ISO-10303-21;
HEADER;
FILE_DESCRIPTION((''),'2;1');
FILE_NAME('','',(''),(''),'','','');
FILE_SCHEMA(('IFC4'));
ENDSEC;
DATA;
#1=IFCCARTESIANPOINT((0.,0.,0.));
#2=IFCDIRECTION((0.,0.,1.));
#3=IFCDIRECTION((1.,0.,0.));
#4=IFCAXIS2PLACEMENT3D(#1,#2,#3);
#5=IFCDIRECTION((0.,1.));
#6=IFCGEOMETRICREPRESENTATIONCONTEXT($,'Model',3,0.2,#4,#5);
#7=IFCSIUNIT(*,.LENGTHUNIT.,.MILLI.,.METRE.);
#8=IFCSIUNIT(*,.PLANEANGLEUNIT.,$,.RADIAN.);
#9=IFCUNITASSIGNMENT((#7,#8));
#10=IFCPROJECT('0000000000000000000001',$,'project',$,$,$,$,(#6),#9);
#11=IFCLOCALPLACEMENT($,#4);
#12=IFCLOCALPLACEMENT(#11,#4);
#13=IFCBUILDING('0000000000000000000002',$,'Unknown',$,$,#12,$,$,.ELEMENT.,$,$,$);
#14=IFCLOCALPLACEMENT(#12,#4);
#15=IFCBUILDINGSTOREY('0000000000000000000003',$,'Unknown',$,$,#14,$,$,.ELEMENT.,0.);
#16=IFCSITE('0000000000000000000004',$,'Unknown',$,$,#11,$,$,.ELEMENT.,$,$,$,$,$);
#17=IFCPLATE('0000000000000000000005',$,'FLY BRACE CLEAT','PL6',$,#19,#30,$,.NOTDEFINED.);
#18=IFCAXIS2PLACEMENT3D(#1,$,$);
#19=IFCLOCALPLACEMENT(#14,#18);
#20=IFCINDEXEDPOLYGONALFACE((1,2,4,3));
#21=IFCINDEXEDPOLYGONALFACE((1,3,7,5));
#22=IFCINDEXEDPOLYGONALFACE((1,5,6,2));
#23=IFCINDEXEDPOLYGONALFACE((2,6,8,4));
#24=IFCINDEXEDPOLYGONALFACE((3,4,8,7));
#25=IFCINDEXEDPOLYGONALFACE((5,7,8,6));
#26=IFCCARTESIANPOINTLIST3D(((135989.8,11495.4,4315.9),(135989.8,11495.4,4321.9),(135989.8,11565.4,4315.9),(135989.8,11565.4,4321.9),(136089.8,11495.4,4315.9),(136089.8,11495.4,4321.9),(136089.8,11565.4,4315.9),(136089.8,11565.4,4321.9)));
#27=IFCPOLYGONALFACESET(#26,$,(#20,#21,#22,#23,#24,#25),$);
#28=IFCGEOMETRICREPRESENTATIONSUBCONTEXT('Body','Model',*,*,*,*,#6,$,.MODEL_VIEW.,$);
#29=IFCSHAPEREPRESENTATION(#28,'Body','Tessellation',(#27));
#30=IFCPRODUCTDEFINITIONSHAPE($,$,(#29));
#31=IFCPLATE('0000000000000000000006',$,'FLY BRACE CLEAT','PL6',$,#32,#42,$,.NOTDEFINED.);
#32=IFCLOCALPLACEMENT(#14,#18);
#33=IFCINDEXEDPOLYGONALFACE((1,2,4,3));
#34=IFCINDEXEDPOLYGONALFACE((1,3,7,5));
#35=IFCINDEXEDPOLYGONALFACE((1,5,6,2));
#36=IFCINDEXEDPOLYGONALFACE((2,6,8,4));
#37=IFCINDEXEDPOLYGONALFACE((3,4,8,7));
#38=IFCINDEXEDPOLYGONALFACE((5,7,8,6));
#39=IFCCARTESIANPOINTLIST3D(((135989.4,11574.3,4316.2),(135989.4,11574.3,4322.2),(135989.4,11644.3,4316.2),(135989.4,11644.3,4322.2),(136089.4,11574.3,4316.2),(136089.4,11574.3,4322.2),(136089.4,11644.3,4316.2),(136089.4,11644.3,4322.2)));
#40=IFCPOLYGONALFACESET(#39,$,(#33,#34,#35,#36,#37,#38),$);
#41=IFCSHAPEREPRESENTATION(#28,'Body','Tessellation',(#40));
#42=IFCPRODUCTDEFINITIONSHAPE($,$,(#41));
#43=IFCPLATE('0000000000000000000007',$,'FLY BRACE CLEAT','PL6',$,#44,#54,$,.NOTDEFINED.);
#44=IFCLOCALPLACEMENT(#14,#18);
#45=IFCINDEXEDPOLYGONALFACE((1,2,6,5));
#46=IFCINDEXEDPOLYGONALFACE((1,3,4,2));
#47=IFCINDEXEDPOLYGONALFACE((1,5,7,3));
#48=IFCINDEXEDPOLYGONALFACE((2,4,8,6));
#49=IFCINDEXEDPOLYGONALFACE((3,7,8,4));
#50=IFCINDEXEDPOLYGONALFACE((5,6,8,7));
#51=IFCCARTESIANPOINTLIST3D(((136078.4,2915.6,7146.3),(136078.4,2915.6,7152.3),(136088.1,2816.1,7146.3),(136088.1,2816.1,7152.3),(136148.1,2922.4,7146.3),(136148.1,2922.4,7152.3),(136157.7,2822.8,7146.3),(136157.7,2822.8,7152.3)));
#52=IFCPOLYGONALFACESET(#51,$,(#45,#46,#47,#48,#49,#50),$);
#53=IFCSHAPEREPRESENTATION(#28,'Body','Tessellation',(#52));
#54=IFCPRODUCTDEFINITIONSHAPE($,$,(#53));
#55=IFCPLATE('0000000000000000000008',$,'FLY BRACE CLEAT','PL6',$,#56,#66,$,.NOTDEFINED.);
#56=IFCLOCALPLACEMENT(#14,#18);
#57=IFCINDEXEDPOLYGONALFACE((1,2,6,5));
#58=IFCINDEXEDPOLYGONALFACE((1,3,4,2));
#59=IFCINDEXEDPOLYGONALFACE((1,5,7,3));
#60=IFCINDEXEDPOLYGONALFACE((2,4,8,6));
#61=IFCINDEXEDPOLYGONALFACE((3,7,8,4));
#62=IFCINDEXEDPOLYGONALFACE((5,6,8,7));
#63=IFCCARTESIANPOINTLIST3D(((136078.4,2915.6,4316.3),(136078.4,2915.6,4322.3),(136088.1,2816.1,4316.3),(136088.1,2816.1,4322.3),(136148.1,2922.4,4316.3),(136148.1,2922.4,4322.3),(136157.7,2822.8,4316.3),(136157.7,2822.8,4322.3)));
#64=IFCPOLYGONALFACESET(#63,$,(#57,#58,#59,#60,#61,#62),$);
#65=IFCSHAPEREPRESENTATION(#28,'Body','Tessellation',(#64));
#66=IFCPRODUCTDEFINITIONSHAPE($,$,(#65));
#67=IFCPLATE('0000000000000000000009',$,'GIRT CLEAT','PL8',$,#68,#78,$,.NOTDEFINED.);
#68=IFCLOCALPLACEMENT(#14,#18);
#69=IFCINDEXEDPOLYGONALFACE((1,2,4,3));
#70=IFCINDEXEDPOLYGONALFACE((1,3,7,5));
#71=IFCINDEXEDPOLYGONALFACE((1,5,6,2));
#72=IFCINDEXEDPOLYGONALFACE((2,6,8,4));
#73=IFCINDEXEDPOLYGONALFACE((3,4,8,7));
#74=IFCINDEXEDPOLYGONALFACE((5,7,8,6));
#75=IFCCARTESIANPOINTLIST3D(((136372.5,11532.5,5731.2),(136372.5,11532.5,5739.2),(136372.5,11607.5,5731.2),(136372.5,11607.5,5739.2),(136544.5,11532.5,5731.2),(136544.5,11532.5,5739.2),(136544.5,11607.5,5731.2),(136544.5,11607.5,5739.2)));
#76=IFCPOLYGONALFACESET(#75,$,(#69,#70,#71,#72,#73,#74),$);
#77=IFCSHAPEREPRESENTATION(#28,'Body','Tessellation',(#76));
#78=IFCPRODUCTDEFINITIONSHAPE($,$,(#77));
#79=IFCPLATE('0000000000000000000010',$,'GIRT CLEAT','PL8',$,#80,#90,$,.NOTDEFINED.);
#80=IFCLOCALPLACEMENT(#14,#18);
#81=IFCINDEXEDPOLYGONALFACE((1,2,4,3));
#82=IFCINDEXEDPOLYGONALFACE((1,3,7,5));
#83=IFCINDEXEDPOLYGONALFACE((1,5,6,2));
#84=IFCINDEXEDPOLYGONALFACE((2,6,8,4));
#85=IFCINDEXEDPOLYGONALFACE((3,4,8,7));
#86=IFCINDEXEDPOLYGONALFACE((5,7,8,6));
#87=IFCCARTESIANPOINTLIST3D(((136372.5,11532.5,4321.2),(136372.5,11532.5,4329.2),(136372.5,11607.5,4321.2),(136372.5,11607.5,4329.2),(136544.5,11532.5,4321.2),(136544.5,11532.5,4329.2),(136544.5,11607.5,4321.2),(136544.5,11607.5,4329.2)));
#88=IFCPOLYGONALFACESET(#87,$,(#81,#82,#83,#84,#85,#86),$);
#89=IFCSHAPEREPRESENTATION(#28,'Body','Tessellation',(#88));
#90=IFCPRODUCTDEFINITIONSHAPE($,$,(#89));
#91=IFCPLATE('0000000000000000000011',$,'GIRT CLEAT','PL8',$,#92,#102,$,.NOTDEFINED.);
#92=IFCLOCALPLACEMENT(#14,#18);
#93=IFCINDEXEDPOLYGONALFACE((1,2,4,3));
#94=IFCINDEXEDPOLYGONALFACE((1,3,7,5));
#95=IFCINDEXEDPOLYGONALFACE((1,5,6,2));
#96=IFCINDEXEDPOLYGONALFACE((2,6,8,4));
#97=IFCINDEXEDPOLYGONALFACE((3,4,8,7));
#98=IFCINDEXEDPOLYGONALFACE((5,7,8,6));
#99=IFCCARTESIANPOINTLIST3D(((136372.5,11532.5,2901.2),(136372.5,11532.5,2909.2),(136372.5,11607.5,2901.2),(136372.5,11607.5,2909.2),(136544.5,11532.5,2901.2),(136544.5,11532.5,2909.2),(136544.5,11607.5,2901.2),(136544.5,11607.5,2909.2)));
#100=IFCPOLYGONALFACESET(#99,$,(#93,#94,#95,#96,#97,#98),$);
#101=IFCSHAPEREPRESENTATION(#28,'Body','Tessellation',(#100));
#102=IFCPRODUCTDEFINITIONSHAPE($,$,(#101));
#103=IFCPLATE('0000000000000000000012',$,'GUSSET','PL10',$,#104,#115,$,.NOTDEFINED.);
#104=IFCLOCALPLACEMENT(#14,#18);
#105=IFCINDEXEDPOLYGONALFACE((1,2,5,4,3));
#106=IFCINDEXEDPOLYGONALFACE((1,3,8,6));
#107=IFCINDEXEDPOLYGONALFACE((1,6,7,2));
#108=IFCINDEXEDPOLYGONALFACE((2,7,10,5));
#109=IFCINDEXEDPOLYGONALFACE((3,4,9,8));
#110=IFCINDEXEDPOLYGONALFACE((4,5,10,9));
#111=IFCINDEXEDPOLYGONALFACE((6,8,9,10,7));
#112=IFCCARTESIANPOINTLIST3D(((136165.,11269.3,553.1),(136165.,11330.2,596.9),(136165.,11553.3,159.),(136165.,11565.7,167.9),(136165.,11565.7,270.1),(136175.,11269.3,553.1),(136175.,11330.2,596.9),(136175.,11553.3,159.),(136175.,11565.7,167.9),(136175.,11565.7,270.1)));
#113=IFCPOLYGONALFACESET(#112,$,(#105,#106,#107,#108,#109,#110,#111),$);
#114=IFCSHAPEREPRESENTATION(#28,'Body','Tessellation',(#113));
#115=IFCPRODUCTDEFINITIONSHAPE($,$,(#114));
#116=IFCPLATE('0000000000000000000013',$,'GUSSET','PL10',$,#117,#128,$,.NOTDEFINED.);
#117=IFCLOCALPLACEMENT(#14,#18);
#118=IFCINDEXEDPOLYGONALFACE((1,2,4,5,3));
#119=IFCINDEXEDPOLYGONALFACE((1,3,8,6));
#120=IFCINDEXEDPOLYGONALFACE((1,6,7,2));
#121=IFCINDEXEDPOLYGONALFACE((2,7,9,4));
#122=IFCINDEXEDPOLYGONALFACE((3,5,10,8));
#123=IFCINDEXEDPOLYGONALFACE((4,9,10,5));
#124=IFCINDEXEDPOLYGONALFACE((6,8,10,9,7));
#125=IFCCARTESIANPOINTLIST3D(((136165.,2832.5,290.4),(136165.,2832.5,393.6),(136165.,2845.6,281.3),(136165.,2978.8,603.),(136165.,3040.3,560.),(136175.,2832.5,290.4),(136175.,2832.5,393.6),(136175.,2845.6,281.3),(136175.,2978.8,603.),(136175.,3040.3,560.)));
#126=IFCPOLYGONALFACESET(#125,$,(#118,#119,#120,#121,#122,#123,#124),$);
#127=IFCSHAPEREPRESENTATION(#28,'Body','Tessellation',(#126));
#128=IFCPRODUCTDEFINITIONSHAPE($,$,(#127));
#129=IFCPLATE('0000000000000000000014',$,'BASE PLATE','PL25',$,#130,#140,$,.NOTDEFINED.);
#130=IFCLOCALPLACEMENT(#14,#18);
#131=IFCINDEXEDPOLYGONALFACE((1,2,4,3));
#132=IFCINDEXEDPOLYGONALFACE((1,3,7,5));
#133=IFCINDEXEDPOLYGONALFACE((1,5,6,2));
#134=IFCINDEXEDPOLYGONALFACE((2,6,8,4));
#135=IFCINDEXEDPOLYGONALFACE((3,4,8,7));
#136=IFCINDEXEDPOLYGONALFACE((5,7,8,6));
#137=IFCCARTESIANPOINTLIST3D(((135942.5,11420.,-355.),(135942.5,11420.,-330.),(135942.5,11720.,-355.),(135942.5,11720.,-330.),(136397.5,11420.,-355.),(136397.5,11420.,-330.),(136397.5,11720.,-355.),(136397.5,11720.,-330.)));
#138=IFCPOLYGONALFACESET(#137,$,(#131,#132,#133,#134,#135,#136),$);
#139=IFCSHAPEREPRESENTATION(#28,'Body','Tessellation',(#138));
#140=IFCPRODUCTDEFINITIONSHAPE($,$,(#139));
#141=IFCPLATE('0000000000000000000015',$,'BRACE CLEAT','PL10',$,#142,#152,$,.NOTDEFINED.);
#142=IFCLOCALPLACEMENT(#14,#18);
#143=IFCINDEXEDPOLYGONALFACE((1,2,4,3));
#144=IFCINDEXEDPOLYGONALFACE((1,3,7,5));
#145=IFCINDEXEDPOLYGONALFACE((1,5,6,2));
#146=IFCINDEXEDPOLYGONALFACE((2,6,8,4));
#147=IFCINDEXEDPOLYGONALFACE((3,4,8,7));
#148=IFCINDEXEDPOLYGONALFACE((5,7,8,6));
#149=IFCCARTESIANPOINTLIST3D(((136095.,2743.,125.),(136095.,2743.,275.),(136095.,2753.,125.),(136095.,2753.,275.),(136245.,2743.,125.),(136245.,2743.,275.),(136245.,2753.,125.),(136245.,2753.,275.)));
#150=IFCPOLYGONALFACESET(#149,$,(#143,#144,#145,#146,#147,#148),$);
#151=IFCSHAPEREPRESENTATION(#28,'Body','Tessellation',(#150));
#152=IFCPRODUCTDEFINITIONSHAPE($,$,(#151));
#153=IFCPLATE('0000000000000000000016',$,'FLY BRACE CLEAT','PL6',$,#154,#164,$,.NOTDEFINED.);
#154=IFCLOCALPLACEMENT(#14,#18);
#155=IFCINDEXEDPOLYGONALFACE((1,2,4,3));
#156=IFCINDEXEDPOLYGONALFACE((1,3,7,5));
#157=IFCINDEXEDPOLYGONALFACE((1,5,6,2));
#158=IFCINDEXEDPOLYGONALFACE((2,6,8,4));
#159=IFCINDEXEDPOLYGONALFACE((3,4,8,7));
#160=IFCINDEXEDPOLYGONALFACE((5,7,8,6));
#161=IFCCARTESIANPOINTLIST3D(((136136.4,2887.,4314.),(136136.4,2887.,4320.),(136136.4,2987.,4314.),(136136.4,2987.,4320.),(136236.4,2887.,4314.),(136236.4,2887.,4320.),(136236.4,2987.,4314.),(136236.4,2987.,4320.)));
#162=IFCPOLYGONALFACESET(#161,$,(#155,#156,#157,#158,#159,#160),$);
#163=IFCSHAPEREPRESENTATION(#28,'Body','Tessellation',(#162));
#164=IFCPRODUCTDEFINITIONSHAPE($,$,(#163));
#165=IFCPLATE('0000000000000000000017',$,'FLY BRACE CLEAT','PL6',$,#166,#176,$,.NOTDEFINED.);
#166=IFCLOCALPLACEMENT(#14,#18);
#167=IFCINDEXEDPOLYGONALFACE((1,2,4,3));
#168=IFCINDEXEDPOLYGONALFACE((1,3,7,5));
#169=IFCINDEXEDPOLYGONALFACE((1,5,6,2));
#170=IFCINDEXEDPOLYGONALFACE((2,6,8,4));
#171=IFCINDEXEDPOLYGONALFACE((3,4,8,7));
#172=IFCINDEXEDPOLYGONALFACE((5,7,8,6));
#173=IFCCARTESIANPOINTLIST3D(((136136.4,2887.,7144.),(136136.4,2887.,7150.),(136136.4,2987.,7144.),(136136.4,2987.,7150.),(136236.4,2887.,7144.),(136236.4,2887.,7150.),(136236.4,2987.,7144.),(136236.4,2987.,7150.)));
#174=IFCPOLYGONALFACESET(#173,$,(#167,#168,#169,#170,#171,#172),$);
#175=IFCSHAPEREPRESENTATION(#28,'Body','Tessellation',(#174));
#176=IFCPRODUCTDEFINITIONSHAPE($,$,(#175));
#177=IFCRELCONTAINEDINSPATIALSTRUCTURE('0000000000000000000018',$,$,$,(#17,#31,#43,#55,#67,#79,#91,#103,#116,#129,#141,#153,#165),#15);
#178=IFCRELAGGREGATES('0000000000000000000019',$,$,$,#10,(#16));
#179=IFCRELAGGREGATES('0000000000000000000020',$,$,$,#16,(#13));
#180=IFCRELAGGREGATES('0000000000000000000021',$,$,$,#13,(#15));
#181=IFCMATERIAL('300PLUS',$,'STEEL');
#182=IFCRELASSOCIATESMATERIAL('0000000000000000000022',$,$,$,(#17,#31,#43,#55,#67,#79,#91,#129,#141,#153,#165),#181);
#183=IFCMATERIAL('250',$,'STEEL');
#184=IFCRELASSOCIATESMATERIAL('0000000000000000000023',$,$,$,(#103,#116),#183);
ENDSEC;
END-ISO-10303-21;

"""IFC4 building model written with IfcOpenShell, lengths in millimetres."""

from ifc_helpers import new_model, si_unit, direction, frame, origin_with_axes, place, context, subcontext, project, spatial, line, indexed_curve, outline, extrude, material, element, save


model = new_model("IFC4")

# Units and contexts
model_context = context("Model", 3, precision=0.2, world=origin_with_axes(), true_north=direction((0.0, 1.0)))
body_context = subcontext(model_context, "Body", "Model", "MODEL_VIEW")
ifc_project = project(units=[si_unit("LENGTHUNIT", "METRE", prefix="MILLI"), si_unit("PLANEANGLEUNIT", "RADIAN")], contexts=[model_context])

# Site, building, storey
site_placement = place(None, origin_with_axes())
site = spatial("IfcSite", under=ifc_project, at=site_placement, Name="Unknown", CompositionType="ELEMENT")
building_placement = place(site_placement, origin_with_axes())
building = spatial("IfcBuilding", under=site, at=building_placement, Name="Unknown", CompositionType="ELEMENT")
storey_placement = place(building_placement, origin_with_axes())
storey = spatial("IfcBuildingStorey", under=building, at=storey_placement, Name="Unknown", CompositionType="ELEMENT", Elevation=0.0)

# Shared definitions
ifc_material_1 = material(Name="300PLUS", Category="STEEL")

# Plates
for number, where, z_axis, x_axis, name in (
    (1, (135989.8, 11565.4, 4318.9), (0.0, 0.0, 1.0), (0.0, -1.0, 0.0), "FLY BRACE CLEAT"),
    (2, (136089.4, 11574.3, 4319.2), (0.0, 0.0, 1.0), (0.0, 1.0, 0.0), "FLY BRACE CLEAT"),
):
    element("IfcPlate", number, at=place(storey_placement, frame(where, z_axis=z_axis, x_axis=x_axis)), inside=storey, material=ifc_material_1, Name=name, Description="PL6", PredefinedType="NOTDEFINED", context=body_context, shape_type="SolidModel", body=[
        extrude(outline(indexed_curve([(0.0, 0.0), (70.0, 0.0), (70.0, 100.0), (0.0, 100.0)], segments=[line(1, 2, 3, 4, 1)])), frame((0.0, 0.0, 3.0), z_axis=(0.0, 0.0, 1.0), x_axis=(1.0, 0.0, 0.0)), (0.0, 0.0, -1.0), 6.0),
    ])
for number, where, z_axis, x_axis, name in (
    (3, (136148.1, 2922.4, 7149.3), (0.0, 0.0, 1.0), (-0.995275, -0.0971, 0.0), "FLY BRACE CLEAT"),
    (4, (136148.1, 2922.4, 4319.3), (0.0, 0.0, 1.0), (-0.995275, -0.0971, 0.0), "FLY BRACE CLEAT"),
):
    element("IfcPlate", number, at=place(storey_placement, frame(where, z_axis=z_axis, x_axis=x_axis)), inside=storey, material=ifc_material_1, Name=name, Description="PL6", PredefinedType="NOTDEFINED", context=body_context, shape_type="SolidModel", body=[
        extrude(outline(indexed_curve([(0.0, 0.0), (70.0, 0.0), (70.0, 100.0), (0.1, 100.1)], segments=[line(1, 2, 3, 4, 1)])), frame((0.0, 0.0, 3.0), z_axis=(0.0, 0.0, 1.0), x_axis=(1.0, 0.0, 0.0)), (0.0, 0.0, -1.0), 6.0),
    ])
for number, where, z_axis, x_axis, name in (
    (5, (136544.5, 11532.5, 5735.2), (0.0, 0.0, 1.0), (0.0, 1.0, 0.0), "GIRT CLEAT"),
    (6, (136544.5, 11532.5, 4325.2), (0.0, 0.0, 1.0), (0.0, 1.0, 0.0), "GIRT CLEAT"),
    (7, (136544.5, 11532.5, 2905.2), (0.0, 0.0, 1.0), (0.0, 1.0, 0.0), "GIRT CLEAT"),
):
    element("IfcPlate", number, at=place(storey_placement, frame(where, z_axis=z_axis, x_axis=x_axis)), inside=storey, material=ifc_material_1, Name=name, Description="PL8", PredefinedType="NOTDEFINED", context=body_context, shape_type="SolidModel", body=[
        extrude(outline(indexed_curve([(0.0, 0.0), (75.0, 0.0), (75.0, 172.0), (0.0, 172.0)], segments=[line(1, 2, 3, 4, 1)])), frame((0.0, 0.0, 4.0), z_axis=(0.0, 0.0, 1.0), x_axis=(1.0, 0.0, 0.0)), (0.0, 0.0, -1.0), 8.0),
    ])
ifc_material_2 = material(Name="250", Category="STEEL")
plate_1_placement = place(storey_placement, frame((136170.0, 11565.7, 167.9), z_axis=(-1.0, 0.0, 0.0), x_axis=(0.0, -0.812403, -0.583096)))
element("IfcPlate", 8, at=plate_1_placement, inside=storey, material=ifc_material_2, Name="GUSSET", Description="PL10", PredefinedType="NOTDEFINED", context=body_context, shape_type="SolidModel", body=[
    extrude(outline(indexed_curve([(0.0, 0.0), (15.3, 0.0), (16.2, 485.8), (-58.8, 485.8), (-59.6, 83.0)], segments=[line(1, 2, 3, 4, 5, 1)])), frame((0.0, 0.0, 5.0), z_axis=(0.0, 0.0, 1.0), x_axis=(1.0, 0.0, 0.0)), (0.0, 0.0, -1.0), 10.0),
])
plate_2_placement = place(storey_placement, frame((136170.0, 2832.5, 290.4), z_axis=(1.0, 0.0, 0.0), x_axis=(0.0, 0.821288, -0.570513)))
element("IfcPlate", 9, at=plate_2_placement, inside=storey, material=ifc_material_2, Name="GUSSET", Description="PL10", PredefinedType="NOTDEFINED", context=body_context, shape_type="SolidModel", body=[
    extrude(outline(indexed_curve([(0.0, 0.0), (16.0, 0.0), (16.9, 340.0), (-58.2, 340.2), (-58.9, 84.8)], segments=[line(1, 2, 3, 4, 5, 1)])), frame((0.0, 0.0, 5.0), z_axis=(0.0, 0.0, 1.0), x_axis=(1.0, 0.0, 0.0)), (0.0, 0.0, -1.0), 10.0),
])
plate_3_placement = place(storey_placement, frame((135942.5, 11420.0, -342.5), z_axis=(0.0, 0.0, 1.0), x_axis=(1.0, 0.0, 0.0)))
element("IfcPlate", 10, at=plate_3_placement, inside=storey, material=ifc_material_1, Name="BASE PLATE", Description="PL25", PredefinedType="NOTDEFINED", context=body_context, shape_type="SolidModel", body=[
    extrude(outline(indexed_curve([(0.0, 0.0), (455.0, 0.0), (455.0, 300.0), (0.0, 300.0)], segments=[line(1, 2, 3, 4, 1)])), frame((0.0, 0.0, 12.5), z_axis=(0.0, 0.0, 1.0), x_axis=(1.0, 0.0, 0.0)), (0.0, 0.0, -1.0), 25.0),
])
plate_4_placement = place(storey_placement, frame((136095.0, 2748.0, 125.0), z_axis=(0.0, -1.0, 0.0), x_axis=(1.0, 0.0, 0.0)))
element("IfcPlate", 11, at=plate_4_placement, inside=storey, material=ifc_material_1, Name="BRACE CLEAT", Description="PL10", PredefinedType="NOTDEFINED", context=body_context, shape_type="SolidModel", body=[
    extrude(outline(indexed_curve([(0.0, 0.0), (150.0, 0.0), (150.0, 150.0), (0.0, 150.0)], segments=[line(1, 2, 3, 4, 1)])), frame((0.0, 0.0, 5.0), z_axis=(0.0, 0.0, 1.0), x_axis=(1.0, 0.0, 0.0)), (0.0, 0.0, -1.0), 10.0),
])
for number, where, z_axis, x_axis, name in (
    (12, (136136.4, 2887.0, 4317.0), (0.0, 0.0, 1.0), (1.0, 0.0, 0.0), "FLY BRACE CLEAT"),
    (13, (136136.4, 2887.0, 7147.0), (0.0, 0.0, 1.0), (1.0, 0.0, 0.0), "FLY BRACE CLEAT"),
):
    element("IfcPlate", number, at=place(storey_placement, frame(where, z_axis=z_axis, x_axis=x_axis)), inside=storey, material=ifc_material_1, Name=name, Description="PL6", PredefinedType="NOTDEFINED", context=body_context, shape_type="SolidModel", body=[
        extrude(outline(indexed_curve([(0.0, 0.0), (100.0, 0.0), (100.0, 100.0), (0.0, 100.0)], segments=[line(1, 2, 3, 4, 1)])), frame((0.0, 0.0, 3.0), z_axis=(0.0, 0.0, 1.0), x_axis=(1.0, 0.0, 0.0)), (0.0, 0.0, -1.0), 6.0),
    ])

save(model, "model.ifc")
